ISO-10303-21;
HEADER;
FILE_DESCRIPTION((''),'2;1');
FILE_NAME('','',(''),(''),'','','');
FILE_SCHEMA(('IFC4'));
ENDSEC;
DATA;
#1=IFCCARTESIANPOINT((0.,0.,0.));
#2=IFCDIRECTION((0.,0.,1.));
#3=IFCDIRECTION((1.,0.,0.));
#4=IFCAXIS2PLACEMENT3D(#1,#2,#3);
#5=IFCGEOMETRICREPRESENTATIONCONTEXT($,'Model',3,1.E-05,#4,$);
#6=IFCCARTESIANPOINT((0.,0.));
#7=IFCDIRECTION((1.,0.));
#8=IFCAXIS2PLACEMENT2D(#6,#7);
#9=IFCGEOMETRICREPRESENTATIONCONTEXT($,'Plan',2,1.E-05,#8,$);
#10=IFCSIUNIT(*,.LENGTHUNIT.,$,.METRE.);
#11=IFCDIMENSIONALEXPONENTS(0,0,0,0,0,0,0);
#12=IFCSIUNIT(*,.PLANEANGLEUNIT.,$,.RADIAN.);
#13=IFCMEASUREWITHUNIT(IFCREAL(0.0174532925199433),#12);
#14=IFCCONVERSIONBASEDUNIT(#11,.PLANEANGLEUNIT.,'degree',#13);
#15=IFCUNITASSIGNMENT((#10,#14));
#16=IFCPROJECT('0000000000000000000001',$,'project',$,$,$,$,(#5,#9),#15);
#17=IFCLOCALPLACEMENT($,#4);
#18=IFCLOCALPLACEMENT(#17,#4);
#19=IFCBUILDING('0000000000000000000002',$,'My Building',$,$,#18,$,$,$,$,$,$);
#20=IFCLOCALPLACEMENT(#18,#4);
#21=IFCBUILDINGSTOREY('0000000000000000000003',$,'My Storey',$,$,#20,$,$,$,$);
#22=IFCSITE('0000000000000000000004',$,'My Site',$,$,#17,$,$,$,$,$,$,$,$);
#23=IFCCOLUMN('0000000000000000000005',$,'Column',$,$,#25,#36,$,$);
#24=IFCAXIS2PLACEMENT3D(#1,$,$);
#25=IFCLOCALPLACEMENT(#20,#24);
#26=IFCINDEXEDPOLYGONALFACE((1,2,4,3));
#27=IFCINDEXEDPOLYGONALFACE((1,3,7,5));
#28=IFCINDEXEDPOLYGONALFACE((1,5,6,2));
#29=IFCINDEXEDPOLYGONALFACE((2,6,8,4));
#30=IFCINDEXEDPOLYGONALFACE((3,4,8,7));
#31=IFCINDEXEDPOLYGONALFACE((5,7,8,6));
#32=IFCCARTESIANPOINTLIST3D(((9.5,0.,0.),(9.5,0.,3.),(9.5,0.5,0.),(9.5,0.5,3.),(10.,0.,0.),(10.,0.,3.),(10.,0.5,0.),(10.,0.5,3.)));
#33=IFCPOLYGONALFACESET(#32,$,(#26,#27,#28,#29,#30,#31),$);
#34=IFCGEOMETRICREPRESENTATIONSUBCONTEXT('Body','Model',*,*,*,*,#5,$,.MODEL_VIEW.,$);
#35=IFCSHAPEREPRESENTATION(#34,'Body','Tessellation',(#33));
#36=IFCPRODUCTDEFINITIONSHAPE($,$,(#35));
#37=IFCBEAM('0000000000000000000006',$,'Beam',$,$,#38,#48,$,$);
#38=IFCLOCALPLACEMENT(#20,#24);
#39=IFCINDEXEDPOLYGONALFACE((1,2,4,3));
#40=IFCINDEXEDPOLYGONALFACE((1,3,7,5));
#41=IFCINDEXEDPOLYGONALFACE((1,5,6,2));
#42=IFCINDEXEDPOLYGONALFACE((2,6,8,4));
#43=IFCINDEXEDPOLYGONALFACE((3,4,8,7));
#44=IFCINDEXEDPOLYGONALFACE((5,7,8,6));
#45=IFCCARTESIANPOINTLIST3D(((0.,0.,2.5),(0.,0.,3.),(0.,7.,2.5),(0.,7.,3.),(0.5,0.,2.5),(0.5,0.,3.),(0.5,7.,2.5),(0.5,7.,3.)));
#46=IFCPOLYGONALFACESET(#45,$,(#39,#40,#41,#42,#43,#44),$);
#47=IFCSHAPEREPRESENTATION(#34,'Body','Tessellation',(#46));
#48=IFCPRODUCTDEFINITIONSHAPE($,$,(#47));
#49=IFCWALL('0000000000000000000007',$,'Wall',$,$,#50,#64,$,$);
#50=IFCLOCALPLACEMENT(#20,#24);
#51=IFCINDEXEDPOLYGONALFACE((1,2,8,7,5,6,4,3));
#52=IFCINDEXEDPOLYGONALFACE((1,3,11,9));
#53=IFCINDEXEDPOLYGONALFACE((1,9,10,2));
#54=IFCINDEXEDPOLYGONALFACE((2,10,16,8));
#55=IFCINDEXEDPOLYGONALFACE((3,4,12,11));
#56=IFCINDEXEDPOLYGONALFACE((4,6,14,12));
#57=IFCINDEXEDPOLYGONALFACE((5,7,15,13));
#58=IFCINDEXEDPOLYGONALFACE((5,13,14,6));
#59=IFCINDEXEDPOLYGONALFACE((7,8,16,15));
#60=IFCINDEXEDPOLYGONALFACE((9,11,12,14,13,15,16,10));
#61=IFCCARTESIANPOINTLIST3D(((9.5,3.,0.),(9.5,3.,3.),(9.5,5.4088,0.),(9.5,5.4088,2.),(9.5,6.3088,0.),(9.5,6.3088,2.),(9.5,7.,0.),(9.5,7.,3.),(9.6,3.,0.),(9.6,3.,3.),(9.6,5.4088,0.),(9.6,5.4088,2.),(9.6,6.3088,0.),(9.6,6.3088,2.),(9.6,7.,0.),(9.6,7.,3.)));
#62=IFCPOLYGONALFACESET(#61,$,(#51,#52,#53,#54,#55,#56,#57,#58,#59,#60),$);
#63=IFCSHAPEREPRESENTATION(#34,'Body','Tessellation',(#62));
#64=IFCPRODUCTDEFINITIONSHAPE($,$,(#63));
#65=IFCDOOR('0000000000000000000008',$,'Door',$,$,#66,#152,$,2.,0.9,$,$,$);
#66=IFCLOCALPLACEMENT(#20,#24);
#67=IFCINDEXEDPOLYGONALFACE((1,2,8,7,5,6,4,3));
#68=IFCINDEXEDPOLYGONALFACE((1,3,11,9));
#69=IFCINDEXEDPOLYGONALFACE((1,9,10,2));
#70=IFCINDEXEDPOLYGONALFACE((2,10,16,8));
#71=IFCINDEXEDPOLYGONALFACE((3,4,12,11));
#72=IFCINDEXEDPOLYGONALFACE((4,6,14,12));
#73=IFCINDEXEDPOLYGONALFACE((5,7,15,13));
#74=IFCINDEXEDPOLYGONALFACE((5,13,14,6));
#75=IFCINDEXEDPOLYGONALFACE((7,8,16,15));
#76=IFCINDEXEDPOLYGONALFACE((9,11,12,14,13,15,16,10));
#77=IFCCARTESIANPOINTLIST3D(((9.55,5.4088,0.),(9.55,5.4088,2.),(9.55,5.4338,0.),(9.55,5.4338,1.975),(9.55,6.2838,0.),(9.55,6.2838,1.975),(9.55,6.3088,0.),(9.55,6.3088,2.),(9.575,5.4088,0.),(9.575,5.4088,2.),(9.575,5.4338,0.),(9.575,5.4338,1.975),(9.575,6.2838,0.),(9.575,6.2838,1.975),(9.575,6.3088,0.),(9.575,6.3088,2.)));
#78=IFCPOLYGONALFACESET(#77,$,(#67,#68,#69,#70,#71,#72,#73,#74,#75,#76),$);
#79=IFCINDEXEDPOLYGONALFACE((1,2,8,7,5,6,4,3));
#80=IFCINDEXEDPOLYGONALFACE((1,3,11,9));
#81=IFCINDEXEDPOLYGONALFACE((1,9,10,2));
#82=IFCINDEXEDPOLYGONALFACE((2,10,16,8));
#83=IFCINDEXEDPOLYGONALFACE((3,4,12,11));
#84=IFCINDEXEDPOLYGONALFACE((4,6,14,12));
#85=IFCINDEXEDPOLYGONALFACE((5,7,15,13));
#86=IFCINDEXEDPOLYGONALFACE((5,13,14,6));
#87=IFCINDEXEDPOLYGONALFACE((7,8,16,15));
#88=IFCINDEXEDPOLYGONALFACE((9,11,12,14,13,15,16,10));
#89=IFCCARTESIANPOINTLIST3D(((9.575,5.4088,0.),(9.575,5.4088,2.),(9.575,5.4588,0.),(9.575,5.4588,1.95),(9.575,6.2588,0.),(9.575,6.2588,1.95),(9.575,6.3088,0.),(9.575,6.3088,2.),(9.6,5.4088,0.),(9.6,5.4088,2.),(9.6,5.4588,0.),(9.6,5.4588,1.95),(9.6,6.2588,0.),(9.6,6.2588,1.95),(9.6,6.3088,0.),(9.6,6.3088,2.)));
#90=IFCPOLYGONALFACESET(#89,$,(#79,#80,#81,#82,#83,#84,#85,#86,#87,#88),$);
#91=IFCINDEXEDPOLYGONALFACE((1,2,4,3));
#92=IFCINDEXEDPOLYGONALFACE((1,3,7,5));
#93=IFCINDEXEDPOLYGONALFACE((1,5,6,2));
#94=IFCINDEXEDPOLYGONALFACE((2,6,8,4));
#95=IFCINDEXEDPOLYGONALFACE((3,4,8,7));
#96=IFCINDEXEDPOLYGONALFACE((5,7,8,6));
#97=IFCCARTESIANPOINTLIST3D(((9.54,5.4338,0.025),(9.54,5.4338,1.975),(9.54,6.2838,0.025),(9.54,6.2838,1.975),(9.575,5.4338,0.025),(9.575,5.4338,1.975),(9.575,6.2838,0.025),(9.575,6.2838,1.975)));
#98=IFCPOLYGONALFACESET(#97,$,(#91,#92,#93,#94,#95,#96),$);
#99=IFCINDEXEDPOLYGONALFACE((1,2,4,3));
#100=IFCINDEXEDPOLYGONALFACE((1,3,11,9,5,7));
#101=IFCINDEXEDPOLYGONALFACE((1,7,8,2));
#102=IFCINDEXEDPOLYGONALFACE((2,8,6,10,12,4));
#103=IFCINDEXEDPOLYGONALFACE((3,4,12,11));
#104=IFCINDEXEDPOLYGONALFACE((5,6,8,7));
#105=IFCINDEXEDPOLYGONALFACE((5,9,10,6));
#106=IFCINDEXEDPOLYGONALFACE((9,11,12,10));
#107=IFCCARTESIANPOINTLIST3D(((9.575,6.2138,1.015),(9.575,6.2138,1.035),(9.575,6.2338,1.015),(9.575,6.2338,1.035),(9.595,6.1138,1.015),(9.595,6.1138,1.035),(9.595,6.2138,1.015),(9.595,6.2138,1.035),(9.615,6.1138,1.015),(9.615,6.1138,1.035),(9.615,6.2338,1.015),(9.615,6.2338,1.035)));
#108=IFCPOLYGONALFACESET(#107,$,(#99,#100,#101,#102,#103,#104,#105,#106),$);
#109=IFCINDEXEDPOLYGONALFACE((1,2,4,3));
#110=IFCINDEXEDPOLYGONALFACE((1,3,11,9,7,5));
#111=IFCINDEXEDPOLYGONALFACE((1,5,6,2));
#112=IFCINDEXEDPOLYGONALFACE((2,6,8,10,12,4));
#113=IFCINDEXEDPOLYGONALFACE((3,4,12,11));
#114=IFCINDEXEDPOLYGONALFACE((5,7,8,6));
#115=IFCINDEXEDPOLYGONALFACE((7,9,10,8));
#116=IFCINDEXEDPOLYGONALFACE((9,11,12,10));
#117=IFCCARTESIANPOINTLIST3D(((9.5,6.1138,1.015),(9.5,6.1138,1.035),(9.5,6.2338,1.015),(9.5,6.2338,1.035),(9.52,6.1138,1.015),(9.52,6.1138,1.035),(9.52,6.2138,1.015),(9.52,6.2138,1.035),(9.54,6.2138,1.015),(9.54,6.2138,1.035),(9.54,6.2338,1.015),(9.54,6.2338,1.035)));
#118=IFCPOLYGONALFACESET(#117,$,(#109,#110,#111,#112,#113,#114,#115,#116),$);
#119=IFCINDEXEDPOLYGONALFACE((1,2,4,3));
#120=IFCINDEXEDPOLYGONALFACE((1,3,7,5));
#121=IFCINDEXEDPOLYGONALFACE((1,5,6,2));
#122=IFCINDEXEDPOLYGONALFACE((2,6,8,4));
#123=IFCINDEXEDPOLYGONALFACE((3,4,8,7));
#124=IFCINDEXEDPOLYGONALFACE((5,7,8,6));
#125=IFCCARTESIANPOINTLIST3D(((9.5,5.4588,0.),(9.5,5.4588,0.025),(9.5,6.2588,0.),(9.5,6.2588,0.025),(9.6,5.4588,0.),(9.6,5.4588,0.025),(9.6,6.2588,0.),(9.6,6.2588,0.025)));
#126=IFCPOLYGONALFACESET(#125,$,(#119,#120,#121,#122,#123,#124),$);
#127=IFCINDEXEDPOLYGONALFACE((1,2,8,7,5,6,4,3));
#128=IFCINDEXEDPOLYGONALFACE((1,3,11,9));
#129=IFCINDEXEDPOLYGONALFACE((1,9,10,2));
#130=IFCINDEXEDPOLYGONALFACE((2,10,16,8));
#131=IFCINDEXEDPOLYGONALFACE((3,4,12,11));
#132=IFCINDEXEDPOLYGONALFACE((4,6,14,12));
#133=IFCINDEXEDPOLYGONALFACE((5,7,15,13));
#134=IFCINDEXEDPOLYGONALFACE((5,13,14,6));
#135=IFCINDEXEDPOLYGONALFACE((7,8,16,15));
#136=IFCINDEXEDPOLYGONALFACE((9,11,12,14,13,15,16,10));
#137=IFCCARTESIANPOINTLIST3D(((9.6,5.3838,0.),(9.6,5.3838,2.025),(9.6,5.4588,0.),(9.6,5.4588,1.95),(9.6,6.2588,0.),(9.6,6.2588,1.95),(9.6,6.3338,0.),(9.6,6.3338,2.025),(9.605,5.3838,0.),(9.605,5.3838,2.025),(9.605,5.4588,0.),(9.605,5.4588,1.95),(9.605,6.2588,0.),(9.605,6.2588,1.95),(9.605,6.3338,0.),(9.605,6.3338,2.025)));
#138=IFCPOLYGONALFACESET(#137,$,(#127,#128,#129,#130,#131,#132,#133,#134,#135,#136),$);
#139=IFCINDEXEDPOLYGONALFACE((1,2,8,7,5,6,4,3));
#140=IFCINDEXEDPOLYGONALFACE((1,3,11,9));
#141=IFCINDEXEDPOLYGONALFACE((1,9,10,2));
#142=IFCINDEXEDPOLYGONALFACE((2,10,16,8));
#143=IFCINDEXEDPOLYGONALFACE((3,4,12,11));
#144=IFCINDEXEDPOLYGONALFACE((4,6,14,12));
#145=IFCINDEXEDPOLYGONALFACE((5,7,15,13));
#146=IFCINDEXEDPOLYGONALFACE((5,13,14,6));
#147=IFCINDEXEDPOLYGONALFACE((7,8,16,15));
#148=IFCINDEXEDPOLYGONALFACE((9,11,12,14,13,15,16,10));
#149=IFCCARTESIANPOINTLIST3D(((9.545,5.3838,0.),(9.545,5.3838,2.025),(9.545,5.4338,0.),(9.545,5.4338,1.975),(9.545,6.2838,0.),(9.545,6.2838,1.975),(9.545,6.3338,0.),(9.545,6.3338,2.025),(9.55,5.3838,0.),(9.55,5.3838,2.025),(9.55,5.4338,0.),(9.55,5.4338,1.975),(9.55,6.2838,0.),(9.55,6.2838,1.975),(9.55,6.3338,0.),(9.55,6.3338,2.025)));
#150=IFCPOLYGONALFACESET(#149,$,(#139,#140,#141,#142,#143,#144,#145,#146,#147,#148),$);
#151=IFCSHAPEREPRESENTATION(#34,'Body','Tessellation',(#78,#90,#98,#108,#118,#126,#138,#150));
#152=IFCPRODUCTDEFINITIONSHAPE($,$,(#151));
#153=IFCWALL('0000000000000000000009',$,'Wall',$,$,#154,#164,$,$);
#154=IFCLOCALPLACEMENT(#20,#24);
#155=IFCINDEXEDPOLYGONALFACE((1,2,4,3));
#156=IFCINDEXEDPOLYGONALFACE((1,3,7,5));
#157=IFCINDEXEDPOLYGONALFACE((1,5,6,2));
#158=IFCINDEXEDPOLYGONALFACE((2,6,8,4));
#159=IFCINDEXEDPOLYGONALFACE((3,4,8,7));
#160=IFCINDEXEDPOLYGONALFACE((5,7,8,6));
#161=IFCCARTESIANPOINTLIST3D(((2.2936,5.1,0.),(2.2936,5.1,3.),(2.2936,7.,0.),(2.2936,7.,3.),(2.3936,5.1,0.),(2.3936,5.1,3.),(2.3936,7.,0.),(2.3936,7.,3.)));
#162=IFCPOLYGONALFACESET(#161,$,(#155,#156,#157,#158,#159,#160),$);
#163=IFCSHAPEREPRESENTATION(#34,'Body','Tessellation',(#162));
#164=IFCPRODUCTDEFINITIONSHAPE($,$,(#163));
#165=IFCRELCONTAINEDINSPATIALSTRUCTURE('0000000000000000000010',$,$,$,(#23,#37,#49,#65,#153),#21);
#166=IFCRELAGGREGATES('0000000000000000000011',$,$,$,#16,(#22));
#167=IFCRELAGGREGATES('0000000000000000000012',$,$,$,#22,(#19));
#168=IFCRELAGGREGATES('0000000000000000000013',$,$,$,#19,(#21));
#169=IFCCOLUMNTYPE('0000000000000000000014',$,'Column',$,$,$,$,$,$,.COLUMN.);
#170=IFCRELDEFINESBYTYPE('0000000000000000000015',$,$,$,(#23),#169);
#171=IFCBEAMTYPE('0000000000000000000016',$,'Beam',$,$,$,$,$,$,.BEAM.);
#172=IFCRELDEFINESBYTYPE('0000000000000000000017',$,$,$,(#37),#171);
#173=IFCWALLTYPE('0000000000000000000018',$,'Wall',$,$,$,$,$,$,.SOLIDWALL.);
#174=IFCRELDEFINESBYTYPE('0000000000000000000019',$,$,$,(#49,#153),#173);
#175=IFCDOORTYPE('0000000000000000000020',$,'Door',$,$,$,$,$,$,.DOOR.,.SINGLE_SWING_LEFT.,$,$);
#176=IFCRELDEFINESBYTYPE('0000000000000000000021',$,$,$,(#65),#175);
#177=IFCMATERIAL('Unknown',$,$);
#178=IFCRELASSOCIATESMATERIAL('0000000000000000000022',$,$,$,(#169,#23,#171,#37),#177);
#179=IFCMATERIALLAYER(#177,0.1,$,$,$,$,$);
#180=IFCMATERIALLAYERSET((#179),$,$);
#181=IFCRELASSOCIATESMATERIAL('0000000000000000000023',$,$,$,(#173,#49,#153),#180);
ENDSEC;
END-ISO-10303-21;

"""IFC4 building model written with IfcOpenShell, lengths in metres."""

from ifc_helpers import new_model, entity, si_unit, converted_unit, frame, origin_with_axes, origin_2d_with_axis, place, context, subcontext, project, spatial, line, indexed_curve, rectangle, outline, extrude, shape, source, transform, mapped, material, layer, layer_set, layer_usage, material_profile, profile_set, profile_usage, type_object, type_shapes, element, fill, save


model = new_model("IFC4")

# Units and contexts
model_context = context("Model", 3, precision=1e-05, world=origin_with_axes())
plan_context = context("Plan", 2, precision=1e-05, world=origin_2d_with_axis())
body_context_1 = subcontext(model_context, "Body", "Model", "MODEL_VIEW")
body_context_2 = subcontext(plan_context, "Body", "Plan", "PLAN_VIEW")
ifc_project = project(units=[si_unit("LENGTHUNIT", "METRE"), converted_unit("PLANEANGLEUNIT", "degree", entity("IfcReal", 0.0174532925199433), si_unit("PLANEANGLEUNIT", "RADIAN"), dimensions=[0, 0, 0, 0, 0, 0, 0])], contexts=[model_context, plan_context])

# Site, building, storey
site_placement = place(None, origin_with_axes())
site = spatial("IfcSite", under=ifc_project, at=site_placement, Name="My Site")
building_placement = place(site_placement, origin_with_axes())
building = spatial("IfcBuilding", under=site, at=building_placement, Name="My Building")
storey_placement = place(building_placement, origin_with_axes())
storey = spatial("IfcBuildingStorey", under=building, at=storey_placement, Name="My Storey")

# Column
ifc_material = material(Name="Unknown")
ifc_material_profile_1 = material_profile(ifc_material, rectangle(XDim=0.5, YDim=0.5))
ifc_profile_set_1 = profile_set([ifc_material_profile_1])
ifc_profile_usage_1 = profile_usage(ifc_profile_set_1, cardinal=5)
column_type = type_object("IfcColumnType", Name="Column", PredefinedType="COLUMN", material=ifc_profile_set_1)
column_placement = place(storey_placement, frame((9.75, 0.25, 0.0), z_axis=(0.0, 0.0, 1.0), x_axis=(1.0, 0.0, 0.0)))
element("IfcColumn", 1, at=column_placement, inside=storey, type_object=column_type, material=ifc_profile_usage_1, Name="Column", context=body_context_1, shape_type="SweptSolid", body=[
    extrude(rectangle(XDim=0.5, YDim=0.5), origin_with_axes(), (0.0, 0.0, 1.0), 3.0),
])

# Beam
ifc_material_profile_2 = material_profile(ifc_material, rectangle(XDim=0.5, YDim=0.5))
ifc_profile_set_2 = profile_set([ifc_material_profile_2])
ifc_profile_usage_2 = profile_usage(ifc_profile_set_2, cardinal=8)
beam_type = type_object("IfcBeamType", Name="Beam", PredefinedType="BEAM", material=ifc_profile_set_2)
beam_placement = place(storey_placement, frame((0.25, 7.0, 3.0), z_axis=(0.0, -1.0, 0.0), x_axis=(1.0, 0.0, 0.0)))
element("IfcBeam", 2, at=beam_placement, inside=storey, type_object=beam_type, material=ifc_profile_usage_2, Name="Beam", context=body_context_1, shape_type="SweptSolid", body=[
    extrude(rectangle(XDim=0.5, YDim=0.5), frame((0.0, -0.25, 0.0), z_axis=(0.0, 0.0, 1.0), x_axis=(1.0, 0.0, 0.0)), (0.0, 0.0, 1.0), 7.0),
])

# Wall, opening, door
ifc_layer = layer(ifc_material, 0.1)
ifc_layer_set = layer_set([ifc_layer])
ifc_layer_usage_1 = layer_usage(ifc_layer_set, "AXIS2", "POSITIVE", 0.0)
wall_type = type_object("IfcWallType", Name="Wall", PredefinedType="SOLIDWALL", material=ifc_layer_set)
wall_1_placement = place(storey_placement, frame((9.6, 3.0, 0.0), z_axis=(0.0, 0.0, 1.0), x_axis=(0.0, 1.0, 0.0)))
wall_1 = element("IfcWall", 3, at=wall_1_placement, inside=storey, type_object=wall_type, material=ifc_layer_usage_1, Name="Wall", context=body_context_1, shape_type="SweptSolid", body=[
    extrude(outline(indexed_curve([(0.0, 0.0), (0.0, 0.1), (4.0, 0.1), (4.0, 0.0)], segments=[line(1, 2, 3, 4, 1)])), origin_with_axes(), (0.0, 0.0, 1.0), 3.0),
])
shared_shape_1 = source(origin_with_axes(), body_context_1, "Body", "SweptSolid", [
    extrude(outline(indexed_curve([(0.0, 0.0), (0.9, 0.0), (0.9, 2.0), (0.0, 2.0)], segments=[line(1, 2, 3, 4, 1)])), frame((0.0, -0.6, 0.0), z_axis=(0.0, -1.0, 0.0), x_axis=(1.0, 0.0, 0.0)), (0.0, 0.0, -1.0), 1.2),
])
opening_1_placement = place(wall_1_placement, frame((2.4088, 0.0, 0.0), z_axis=(0.0, 0.0, 1.0), x_axis=(1.0, 0.0, 0.0)))
opening_1 = element("IfcOpeningElement", 4, at=opening_1_placement, cuts=wall_1, PredefinedType="OPENING", context=body_context_1, shape_type="MappedRepresentation", body=[
    mapped(shared_shape_1, transform((0.0, 0.0, 0.0), x_axis=(1.0, 0.0, 0.0), y_axis=(0.0, 1.0, 0.0), z_axis=(0.0, 0.0, 1.0), scale=1.0)),
])
door_type = type_object("IfcDoorType", Name="Door", OperationType="SINGLE_SWING_LEFT", PredefinedType="DOOR")
shared_shape_2 = source(origin_with_axes(), body_context_1, "Body", "SweptSolid", [
    extrude(outline(indexed_curve([(0.0, 0.0), (0.0, 2.0), (0.9, 2.0), (0.9, 0.0), (0.875, 0.0), (0.875, 1.975), (0.025, 1.975), (0.025, 0.0)], segments=[line(1, 2, 3, 4, 5, 6, 7, 8, 1)])), frame((0.0, 0.025, 0.0), z_axis=(0.0, -1.0, 0.0), x_axis=(1.0, 0.0, 0.0)), (0.0, 0.0, -1.0), 0.025),
    extrude(outline(indexed_curve([(0.0, 0.0), (0.0, 2.0), (0.9, 2.0), (0.9, 0.0), (0.85, 0.0), (0.85, 1.95), (0.05, 1.95), (0.05, 0.0)], segments=[line(1, 2, 3, 4, 5, 6, 7, 8, 1)])), frame((0.0, 0.0, 0.0), z_axis=(0.0, -1.0, 0.0), x_axis=(1.0, 0.0, 0.0)), (0.0, 0.0, -1.0), 0.025),
    extrude(outline(indexed_curve([(0.0, 0.0), (0.85, 0.0), (0.85, 0.035), (0.0, 0.035)], segments=[line(1, 2, 3, 4, 1)])), frame((0.025, 0.025, 0.025), z_axis=(0.0, 0.0, 1.0), x_axis=(1.0, 0.0, 0.0)), (0.0, 0.0, 1.0), 1.95),
    extrude(outline(indexed_curve([(0.0, 0.0), (0.0, -0.04), (-0.12, -0.04), (-0.12, -0.02), (-0.02, -0.02), (-0.02, 0.0)], segments=[line(1, 2, 3, 4, 5, 6, 1)])), frame((0.825, 0.025, 1.015), z_axis=(0.0, 0.0, 1.0), x_axis=(1.0, 0.0, 0.0)), (0.0, 0.0, 1.0), 0.02),
    extrude(outline(indexed_curve([(0.0, 0.0), (0.0, 0.04), (-0.12, 0.04), (-0.12, 0.02), (-0.02, 0.02), (-0.02, 0.0)], segments=[line(1, 2, 3, 4, 5, 6, 1)])), frame((0.825, 0.06, 1.015), z_axis=(0.0, 0.0, 1.0), x_axis=(1.0, 0.0, 0.0)), (0.0, 0.0, 1.0), 0.02),
    extrude(outline(indexed_curve([(0.0, 0.0), (0.8, 0.0), (0.8, 0.1), (0.0, 0.1)], segments=[line(1, 2, 3, 4, 1)])), frame((0.05, 0.0, 0.0), z_axis=(0.0, 0.0, 1.0), x_axis=(1.0, 0.0, 0.0)), (0.0, 0.0, 1.0), 0.025),
    extrude(outline(indexed_curve([(0.0, 0.0), (0.0, 2.025), (0.95, 2.025), (0.95, 0.0), (0.875, 0.0), (0.875, 1.95), (0.075, 1.95), (0.075, 0.0)], segments=[line(1, 2, 3, 4, 5, 6, 7, 8, 1)])), frame((-0.025, -0.005, 0.0), z_axis=(0.0, -1.0, 0.0), x_axis=(1.0, 0.0, 0.0)), (0.0, 0.0, -1.0), 0.005),
    extrude(outline(indexed_curve([(0.0, 0.0), (0.0, 2.025), (0.95, 2.025), (0.95, 0.0), (0.9, 0.0), (0.9, 1.975), (0.05, 1.975), (0.05, 0.0)], segments=[line(1, 2, 3, 4, 5, 6, 7, 8, 1)])), frame((-0.025, 0.05, 0.0), z_axis=(0.0, -1.0, 0.0), x_axis=(1.0, 0.0, 0.0)), (0.0, 0.0, -1.0), 0.005),
])
shared_shape_3 = source(origin_with_axes(), body_context_2, "Body", "Curve2D", [
    entity("IfcIndexedPolyCurve", entity("IfcCartesianPointList2D", [[0.0, 0.0], [0.0, 0.05], [0.025, 0.05], [0.025, 0.025], [0.05, 0.025], [0.05, 0.0]]), [entity("IfcLineIndex", [1, 2, 3, 4, 5, 6, 1])]),
    entity("IfcIndexedPolyCurve", entity("IfcCartesianPointList2D", [[0.9, 0.0], [0.9, 0.05], [0.875, 0.05], [0.875, 0.025], [0.85, 0.025], [0.85, 0.0]]), [entity("IfcLineIndex", [1, 2, 3, 4, 5, 6, 1])]),
    entity("IfcTrimmedCurve", entity("IfcEllipse", entity("IfcAxis2Placement2D", entity("IfcCartesianPoint", [0.06, 0.05]), entity("IfcDirection", [1.0, 0.0])), 0.815, 0.85), [entity("IfcCartesianPoint", [0.875, 0.05])], [entity("IfcCartesianPoint", [0.06, 0.9])], True, "CARTESIAN"),
    entity("IfcIndexedPolyCurve", entity("IfcCartesianPointList2D", [[0.025, 0.05], [0.06, 0.05], [0.06, 0.9], [0.025, 0.9]]), [entity("IfcLineIndex", [1, 2, 3, 4, 1])]),
])
type_shapes(door_type, [shared_shape_2, shared_shape_3])
door_1_placement = place(opening_1_placement, frame((0.0, 0.0, 0.0), z_axis=(0.0, 0.0, 1.0), x_axis=(1.0, 0.0, 0.0)))
door_1 = element("IfcDoor", 5, at=door_1_placement, inside=storey, type_object=door_type, Name="Door", OverallHeight=2.0, OverallWidth=0.9, shapes=[
    shape(body_context_1, "Body", "MappedRepresentation", [mapped(shared_shape_2, transform((0.0, 0.0, 0.0), x_axis=(1.0, 0.0, 0.0), y_axis=(0.0, 1.0, 0.0), z_axis=(0.0, 0.0, 1.0), scale=1.0))]),
    shape(body_context_2, "Body", "MappedRepresentation", [mapped(shared_shape_3, transform((0.0, 0.0, 0.0), x_axis=(1.0, 0.0, 0.0), y_axis=(0.0, 1.0, 0.0), z_axis=(0.0, 0.0, 1.0), scale=1.0))]),
])
fill(opening_1, door_1)

# Wall
ifc_layer_usage_2 = layer_usage(ifc_layer_set, "AXIS2", "POSITIVE", 0.0)
wall_2_placement = place(storey_placement, frame((2.2936, 7.0, 0.0), z_axis=(0.0, 0.0, 1.0), x_axis=(0.0, -1.0, 0.0)))
element("IfcWall", 6, at=wall_2_placement, inside=storey, type_object=wall_type, material=ifc_layer_usage_2, Name="Wall", context=body_context_1, shape_type="SweptSolid", body=[
    extrude(outline(indexed_curve([(0.0, 0.0), (0.0, 0.1), (1.9, 0.1), (1.9, 0.0)], segments=[line(1, 2, 3, 4, 1)])), origin_with_axes(), (0.0, 0.0, 1.0), 3.0),
])

save(model, "model.ifc")
